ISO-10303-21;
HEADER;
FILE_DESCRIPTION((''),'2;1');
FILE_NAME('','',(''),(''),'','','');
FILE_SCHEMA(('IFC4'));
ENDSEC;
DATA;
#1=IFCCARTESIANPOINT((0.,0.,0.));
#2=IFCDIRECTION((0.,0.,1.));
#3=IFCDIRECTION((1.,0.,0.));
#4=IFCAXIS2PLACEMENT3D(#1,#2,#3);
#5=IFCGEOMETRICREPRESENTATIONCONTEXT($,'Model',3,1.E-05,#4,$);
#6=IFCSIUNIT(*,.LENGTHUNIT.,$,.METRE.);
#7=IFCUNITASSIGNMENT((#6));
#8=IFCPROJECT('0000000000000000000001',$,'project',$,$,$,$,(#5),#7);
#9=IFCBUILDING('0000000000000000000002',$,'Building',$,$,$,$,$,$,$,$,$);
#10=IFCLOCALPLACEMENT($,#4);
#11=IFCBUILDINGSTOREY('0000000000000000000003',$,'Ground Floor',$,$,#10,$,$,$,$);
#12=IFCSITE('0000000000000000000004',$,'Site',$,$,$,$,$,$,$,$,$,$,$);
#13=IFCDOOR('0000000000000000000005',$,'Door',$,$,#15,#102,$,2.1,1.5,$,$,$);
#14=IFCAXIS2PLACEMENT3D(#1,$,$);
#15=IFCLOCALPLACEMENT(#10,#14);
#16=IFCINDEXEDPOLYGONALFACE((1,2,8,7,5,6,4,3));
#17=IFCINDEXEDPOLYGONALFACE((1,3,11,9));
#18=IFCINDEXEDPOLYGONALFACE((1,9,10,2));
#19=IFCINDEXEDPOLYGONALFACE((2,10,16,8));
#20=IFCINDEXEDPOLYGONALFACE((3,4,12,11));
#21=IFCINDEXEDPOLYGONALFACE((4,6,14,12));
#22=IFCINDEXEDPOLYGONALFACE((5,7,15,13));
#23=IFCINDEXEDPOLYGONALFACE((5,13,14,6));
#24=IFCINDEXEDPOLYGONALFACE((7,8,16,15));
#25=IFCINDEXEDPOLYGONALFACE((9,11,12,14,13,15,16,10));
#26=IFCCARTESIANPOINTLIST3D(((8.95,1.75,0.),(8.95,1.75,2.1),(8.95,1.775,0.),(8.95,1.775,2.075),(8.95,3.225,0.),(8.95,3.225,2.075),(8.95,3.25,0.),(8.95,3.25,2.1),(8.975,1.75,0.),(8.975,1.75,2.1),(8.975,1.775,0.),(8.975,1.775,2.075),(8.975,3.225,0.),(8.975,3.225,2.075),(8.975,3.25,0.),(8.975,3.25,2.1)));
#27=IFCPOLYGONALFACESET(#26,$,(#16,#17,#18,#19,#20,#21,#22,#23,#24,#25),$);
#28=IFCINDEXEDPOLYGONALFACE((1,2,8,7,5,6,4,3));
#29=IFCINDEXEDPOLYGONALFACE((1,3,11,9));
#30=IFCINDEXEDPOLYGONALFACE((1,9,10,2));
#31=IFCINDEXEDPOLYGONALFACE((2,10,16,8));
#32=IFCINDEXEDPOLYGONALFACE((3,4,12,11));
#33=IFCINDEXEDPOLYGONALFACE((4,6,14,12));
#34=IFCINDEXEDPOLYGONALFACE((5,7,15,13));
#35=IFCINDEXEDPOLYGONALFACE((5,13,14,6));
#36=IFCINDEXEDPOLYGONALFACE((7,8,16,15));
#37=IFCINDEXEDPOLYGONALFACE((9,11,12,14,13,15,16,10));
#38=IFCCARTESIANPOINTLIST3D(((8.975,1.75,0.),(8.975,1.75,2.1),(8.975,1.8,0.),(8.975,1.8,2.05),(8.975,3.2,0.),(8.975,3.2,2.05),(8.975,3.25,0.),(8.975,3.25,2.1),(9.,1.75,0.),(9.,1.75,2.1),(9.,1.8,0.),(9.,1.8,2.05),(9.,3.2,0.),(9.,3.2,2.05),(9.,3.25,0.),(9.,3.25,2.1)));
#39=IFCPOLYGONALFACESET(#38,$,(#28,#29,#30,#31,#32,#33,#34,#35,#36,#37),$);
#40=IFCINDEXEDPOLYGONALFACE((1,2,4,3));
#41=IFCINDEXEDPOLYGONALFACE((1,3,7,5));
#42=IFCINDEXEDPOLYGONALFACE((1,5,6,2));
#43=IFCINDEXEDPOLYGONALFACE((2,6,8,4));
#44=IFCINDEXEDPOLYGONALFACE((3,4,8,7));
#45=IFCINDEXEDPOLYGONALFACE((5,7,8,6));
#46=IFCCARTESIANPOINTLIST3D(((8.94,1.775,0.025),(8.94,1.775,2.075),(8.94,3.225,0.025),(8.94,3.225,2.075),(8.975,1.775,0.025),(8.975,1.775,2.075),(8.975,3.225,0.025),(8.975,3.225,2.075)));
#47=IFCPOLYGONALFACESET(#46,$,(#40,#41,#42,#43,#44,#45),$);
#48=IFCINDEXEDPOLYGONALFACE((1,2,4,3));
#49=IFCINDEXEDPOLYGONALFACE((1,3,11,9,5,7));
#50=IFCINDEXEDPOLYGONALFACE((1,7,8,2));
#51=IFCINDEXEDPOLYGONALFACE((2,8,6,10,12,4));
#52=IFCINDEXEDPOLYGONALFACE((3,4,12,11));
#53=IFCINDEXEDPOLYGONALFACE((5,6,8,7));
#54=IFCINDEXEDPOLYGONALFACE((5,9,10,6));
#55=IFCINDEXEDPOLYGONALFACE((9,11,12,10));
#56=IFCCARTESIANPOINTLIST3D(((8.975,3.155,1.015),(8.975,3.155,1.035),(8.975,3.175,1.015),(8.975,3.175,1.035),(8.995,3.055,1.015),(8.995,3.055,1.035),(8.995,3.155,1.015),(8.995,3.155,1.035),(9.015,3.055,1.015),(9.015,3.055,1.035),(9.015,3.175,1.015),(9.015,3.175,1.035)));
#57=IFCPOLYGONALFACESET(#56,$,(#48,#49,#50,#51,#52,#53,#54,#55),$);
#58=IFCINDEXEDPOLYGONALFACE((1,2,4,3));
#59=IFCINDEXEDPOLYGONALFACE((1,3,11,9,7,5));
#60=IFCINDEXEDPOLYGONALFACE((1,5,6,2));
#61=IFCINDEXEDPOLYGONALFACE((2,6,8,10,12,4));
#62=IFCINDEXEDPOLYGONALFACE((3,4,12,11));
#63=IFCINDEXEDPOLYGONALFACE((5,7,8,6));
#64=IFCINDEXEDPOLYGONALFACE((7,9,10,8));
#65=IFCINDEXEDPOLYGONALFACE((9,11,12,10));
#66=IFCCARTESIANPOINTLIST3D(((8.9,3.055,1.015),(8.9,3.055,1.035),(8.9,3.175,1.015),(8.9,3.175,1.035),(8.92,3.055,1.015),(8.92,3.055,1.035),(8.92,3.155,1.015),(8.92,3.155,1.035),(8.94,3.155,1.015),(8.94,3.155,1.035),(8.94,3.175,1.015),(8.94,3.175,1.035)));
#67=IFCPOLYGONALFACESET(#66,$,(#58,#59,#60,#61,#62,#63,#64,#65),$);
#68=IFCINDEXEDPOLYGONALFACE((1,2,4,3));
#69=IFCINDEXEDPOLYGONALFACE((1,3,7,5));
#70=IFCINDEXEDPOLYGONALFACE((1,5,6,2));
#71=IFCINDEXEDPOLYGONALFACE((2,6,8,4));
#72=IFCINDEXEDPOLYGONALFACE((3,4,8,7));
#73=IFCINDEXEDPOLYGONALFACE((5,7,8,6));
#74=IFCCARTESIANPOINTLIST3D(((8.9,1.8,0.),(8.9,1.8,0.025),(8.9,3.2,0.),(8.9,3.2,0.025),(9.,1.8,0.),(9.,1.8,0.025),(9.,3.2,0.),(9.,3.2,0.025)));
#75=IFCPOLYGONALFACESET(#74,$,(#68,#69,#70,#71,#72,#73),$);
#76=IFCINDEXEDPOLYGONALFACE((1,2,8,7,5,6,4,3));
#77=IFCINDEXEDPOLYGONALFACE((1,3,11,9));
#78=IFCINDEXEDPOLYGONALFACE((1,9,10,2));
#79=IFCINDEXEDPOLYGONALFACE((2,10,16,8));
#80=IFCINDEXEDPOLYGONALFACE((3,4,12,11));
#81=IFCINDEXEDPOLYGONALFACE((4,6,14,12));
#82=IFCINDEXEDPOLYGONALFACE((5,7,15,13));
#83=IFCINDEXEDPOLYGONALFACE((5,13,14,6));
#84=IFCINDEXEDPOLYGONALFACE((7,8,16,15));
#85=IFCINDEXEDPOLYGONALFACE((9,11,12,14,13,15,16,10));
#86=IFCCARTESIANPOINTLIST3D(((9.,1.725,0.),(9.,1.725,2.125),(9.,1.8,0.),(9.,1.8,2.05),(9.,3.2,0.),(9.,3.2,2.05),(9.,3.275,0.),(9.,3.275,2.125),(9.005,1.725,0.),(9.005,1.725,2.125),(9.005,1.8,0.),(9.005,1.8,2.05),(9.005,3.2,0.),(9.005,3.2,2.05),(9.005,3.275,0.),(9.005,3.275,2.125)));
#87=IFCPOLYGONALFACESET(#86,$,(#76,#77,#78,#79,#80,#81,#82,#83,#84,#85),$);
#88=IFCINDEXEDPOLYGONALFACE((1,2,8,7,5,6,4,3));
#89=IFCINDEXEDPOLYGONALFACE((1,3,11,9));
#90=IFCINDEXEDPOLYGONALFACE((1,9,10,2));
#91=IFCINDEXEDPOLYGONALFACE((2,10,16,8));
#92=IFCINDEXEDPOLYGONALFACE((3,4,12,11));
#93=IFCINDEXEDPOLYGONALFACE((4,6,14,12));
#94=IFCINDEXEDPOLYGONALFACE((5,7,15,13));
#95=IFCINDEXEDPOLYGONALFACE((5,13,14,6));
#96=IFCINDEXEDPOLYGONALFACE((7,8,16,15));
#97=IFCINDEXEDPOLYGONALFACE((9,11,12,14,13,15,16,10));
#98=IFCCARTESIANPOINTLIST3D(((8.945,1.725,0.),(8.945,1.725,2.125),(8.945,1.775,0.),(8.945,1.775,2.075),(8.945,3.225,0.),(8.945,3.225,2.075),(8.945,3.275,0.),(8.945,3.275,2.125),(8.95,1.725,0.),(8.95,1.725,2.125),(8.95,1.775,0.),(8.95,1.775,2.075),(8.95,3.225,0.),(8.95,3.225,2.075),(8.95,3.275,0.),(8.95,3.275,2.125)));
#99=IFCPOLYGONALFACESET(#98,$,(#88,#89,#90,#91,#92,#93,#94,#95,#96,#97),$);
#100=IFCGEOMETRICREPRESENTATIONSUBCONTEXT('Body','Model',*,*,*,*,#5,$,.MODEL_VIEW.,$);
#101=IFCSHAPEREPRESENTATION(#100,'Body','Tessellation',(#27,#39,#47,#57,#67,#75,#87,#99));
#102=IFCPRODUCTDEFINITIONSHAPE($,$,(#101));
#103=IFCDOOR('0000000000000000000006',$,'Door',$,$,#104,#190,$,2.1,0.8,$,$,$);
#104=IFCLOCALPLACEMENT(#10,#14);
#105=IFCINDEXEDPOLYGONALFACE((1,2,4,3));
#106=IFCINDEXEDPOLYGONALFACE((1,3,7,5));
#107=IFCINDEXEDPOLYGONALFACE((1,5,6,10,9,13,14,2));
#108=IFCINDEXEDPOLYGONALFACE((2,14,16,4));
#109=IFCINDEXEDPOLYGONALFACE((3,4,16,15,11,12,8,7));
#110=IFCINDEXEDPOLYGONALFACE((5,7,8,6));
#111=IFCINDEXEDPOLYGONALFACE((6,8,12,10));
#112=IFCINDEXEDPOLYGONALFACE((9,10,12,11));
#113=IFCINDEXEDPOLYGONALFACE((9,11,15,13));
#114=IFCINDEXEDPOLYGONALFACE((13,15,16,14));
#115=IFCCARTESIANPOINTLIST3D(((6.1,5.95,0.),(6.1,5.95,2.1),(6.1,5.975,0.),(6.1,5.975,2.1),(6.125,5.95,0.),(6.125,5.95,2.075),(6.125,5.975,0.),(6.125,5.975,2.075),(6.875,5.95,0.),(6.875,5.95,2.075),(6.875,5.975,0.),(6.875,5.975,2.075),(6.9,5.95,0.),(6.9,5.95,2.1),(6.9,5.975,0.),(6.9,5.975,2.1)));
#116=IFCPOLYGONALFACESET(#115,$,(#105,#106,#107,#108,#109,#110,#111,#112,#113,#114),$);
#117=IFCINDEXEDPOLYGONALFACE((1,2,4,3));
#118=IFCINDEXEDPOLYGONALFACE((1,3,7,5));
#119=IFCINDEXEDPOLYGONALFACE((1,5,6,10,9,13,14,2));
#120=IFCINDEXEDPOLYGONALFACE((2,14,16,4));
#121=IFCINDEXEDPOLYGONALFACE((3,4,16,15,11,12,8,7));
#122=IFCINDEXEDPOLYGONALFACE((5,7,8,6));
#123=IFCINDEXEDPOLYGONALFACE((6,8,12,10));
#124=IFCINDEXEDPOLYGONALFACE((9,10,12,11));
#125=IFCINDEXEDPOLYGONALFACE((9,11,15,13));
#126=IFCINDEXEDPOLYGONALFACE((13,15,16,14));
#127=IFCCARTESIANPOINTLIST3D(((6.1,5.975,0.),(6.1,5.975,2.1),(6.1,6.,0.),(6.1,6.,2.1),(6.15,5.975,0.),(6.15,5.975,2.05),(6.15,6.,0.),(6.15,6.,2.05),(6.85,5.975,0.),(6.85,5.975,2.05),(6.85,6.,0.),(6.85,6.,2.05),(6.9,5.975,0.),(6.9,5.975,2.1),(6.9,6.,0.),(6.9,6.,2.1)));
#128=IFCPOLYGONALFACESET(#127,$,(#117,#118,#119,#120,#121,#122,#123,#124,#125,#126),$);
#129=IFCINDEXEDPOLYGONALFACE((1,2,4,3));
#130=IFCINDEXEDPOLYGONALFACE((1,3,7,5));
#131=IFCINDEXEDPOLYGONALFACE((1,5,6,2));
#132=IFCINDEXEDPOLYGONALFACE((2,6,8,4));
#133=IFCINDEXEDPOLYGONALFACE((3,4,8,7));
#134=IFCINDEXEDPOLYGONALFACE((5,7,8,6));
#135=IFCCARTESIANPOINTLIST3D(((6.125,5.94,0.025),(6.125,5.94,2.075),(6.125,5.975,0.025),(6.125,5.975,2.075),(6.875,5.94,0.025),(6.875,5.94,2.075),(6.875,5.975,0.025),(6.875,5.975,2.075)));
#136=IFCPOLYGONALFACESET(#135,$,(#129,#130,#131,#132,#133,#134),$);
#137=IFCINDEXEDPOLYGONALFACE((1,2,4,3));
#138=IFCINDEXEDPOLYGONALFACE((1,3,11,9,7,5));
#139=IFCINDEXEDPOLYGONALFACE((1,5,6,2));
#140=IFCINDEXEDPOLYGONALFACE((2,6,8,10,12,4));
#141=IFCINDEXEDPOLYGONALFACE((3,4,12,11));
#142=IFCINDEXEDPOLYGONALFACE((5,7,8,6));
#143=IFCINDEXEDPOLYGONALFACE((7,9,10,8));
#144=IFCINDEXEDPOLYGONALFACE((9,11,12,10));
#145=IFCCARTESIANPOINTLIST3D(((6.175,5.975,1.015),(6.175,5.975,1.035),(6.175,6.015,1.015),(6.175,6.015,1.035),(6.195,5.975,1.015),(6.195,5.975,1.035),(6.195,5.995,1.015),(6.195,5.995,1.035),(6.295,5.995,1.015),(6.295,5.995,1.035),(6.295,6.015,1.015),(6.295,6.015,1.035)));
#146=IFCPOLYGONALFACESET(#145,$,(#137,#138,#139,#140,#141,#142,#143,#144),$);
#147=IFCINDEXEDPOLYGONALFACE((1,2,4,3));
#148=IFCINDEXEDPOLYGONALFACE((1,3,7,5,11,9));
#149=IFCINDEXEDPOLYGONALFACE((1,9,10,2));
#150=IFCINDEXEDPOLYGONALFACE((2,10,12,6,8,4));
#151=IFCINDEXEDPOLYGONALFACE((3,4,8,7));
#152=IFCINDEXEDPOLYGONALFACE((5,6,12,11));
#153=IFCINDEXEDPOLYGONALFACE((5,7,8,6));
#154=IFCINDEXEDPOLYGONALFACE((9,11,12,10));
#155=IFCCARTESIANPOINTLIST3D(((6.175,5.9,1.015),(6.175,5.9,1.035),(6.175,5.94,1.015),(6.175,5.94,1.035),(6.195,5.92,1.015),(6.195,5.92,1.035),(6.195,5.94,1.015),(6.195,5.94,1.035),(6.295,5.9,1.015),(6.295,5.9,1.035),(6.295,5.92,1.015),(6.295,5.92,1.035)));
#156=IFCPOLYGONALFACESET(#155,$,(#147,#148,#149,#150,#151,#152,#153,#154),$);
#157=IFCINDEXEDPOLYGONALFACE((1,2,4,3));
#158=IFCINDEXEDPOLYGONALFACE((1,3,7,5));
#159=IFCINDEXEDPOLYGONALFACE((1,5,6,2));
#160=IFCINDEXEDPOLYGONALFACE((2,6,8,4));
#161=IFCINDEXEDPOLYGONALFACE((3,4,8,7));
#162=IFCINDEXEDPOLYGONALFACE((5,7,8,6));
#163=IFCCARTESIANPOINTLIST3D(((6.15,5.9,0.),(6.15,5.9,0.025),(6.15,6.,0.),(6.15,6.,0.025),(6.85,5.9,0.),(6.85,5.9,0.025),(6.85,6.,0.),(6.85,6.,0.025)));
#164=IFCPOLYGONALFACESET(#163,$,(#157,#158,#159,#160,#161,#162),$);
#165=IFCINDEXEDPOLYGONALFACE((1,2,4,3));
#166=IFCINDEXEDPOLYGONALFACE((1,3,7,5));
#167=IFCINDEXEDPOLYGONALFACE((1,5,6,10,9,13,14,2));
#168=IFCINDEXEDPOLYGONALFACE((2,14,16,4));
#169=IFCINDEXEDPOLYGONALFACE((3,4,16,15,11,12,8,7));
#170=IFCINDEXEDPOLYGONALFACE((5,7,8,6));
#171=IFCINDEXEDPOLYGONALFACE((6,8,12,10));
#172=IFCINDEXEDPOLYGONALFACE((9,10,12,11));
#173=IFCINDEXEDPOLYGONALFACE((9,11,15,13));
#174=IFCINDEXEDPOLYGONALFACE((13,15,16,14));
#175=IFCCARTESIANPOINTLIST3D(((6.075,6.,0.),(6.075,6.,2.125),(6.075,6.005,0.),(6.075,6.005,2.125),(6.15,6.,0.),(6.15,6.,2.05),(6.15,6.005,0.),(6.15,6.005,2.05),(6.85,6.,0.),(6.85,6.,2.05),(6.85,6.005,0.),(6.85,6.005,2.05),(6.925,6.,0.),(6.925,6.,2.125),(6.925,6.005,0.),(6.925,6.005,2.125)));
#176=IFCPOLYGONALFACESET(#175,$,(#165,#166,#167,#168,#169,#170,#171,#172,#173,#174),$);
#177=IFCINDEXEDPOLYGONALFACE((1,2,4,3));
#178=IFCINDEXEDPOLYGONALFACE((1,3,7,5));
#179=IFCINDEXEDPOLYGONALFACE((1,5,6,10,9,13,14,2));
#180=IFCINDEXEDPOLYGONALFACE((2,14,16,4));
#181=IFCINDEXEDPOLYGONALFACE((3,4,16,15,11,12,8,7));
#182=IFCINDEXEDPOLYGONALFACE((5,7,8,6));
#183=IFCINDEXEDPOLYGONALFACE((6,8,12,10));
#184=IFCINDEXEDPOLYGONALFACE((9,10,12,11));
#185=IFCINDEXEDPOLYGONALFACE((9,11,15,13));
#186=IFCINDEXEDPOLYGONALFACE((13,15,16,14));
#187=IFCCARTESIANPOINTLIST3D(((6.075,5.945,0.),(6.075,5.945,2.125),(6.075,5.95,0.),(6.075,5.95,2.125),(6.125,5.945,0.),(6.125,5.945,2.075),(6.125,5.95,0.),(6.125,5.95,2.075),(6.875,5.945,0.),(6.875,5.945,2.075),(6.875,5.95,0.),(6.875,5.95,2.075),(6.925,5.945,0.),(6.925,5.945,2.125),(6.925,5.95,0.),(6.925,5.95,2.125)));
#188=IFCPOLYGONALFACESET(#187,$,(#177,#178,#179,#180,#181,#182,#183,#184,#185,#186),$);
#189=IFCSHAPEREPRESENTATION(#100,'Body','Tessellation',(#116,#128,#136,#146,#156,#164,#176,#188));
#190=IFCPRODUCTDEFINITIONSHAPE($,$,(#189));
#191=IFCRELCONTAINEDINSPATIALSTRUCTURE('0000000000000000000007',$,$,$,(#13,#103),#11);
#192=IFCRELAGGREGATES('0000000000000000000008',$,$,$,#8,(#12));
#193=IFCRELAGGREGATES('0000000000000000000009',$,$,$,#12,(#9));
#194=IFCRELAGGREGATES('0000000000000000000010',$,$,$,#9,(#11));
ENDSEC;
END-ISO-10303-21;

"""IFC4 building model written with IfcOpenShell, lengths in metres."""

from ifc_helpers import new_model, si_unit, frame, origin_with_axes, place, context, subcontext, project, spatial, line, indexed_curve, outline, extrude, element, save


model = new_model("IFC4")

# Units and contexts
model_context = context("Model", 3, precision=1e-05, world=origin_with_axes())
body_context = subcontext(model_context, "Body", "Model", "MODEL_VIEW")
ifc_project = project(units=[si_unit("LENGTHUNIT", "METRE")], contexts=[model_context])

# Site, building, storey
site = spatial("IfcSite", under=ifc_project, Name="Site")
building = spatial("IfcBuilding", under=site, Name="Building")
storey_placement = place(None, origin_with_axes())
storey = spatial("IfcBuildingStorey", under=building, at=storey_placement, Name="Ground Floor")

# Doors
door_1_placement = place(storey_placement, frame((9.0, 1.75, 0.0), z_axis=(0.0, 0.0, 1.0), x_axis=(0.0, 1.0, 0.0)))
element("IfcDoor", 1, at=door_1_placement, inside=storey, Name="Door", OverallHeight=2.1, OverallWidth=1.5, context=body_context, shape_type="SweptSolid", body=[
    extrude(outline(indexed_curve([(0.0, 0.0), (0.0, 2.1), (1.5, 2.1), (1.5, 0.0), (1.475, 0.0), (1.475, 2.075), (0.025, 2.075), (0.025, 0.0)], segments=[line(1, 2, 3, 4, 5, 6, 7, 8, 1)])), frame((0.0, 0.025, 0.0), z_axis=(0.0, -1.0, 0.0), x_axis=(1.0, 0.0, 0.0)), (0.0, 0.0, -1.0), 0.025),
    extrude(outline(indexed_curve([(0.0, 0.0), (0.0, 2.1), (1.5, 2.1), (1.5, 0.0), (1.45, 0.0), (1.45, 2.05), (0.05, 2.05), (0.05, 0.0)], segments=[line(1, 2, 3, 4, 5, 6, 7, 8, 1)])), frame((0.0, 0.0, 0.0), z_axis=(0.0, -1.0, 0.0), x_axis=(1.0, 0.0, 0.0)), (0.0, 0.0, -1.0), 0.025),
    extrude(outline(indexed_curve([(0.0, 0.0), (1.45, 0.0), (1.45, 0.035), (0.0, 0.035)], segments=[line(1, 2, 3, 4, 1)])), frame((0.025, 0.025, 0.025), z_axis=(0.0, 0.0, 1.0), x_axis=(1.0, 0.0, 0.0)), (0.0, 0.0, 1.0), 2.05),
    extrude(outline(indexed_curve([(0.0, 0.0), (0.0, -0.04), (-0.12, -0.04), (-0.12, -0.02), (-0.02, -0.02), (-0.02, 0.0)], segments=[line(1, 2, 3, 4, 5, 6, 1)])), frame((1.425, 0.025, 1.015), z_axis=(0.0, 0.0, 1.0), x_axis=(1.0, 0.0, 0.0)), (0.0, 0.0, 1.0), 0.02),
    extrude(outline(indexed_curve([(0.0, 0.0), (0.0, 0.04), (-0.12, 0.04), (-0.12, 0.02), (-0.02, 0.02), (-0.02, 0.0)], segments=[line(1, 2, 3, 4, 5, 6, 1)])), frame((1.425, 0.06, 1.015), z_axis=(0.0, 0.0, 1.0), x_axis=(1.0, 0.0, 0.0)), (0.0, 0.0, 1.0), 0.02),
    extrude(outline(indexed_curve([(0.0, 0.0), (1.4, 0.0), (1.4, 0.1), (0.0, 0.1)], segments=[line(1, 2, 3, 4, 1)])), frame((0.05, 0.0, 0.0), z_axis=(0.0, 0.0, 1.0), x_axis=(1.0, 0.0, 0.0)), (0.0, 0.0, 1.0), 0.025),
    extrude(outline(indexed_curve([(0.0, 0.0), (0.0, 2.125), (1.55, 2.125), (1.55, 0.0), (1.475, 0.0), (1.475, 2.05), (0.075, 2.05), (0.075, 0.0)], segments=[line(1, 2, 3, 4, 5, 6, 7, 8, 1)])), frame((-0.025, -0.005, 0.0), z_axis=(0.0, -1.0, 0.0), x_axis=(1.0, 0.0, 0.0)), (0.0, 0.0, -1.0), 0.005),
    extrude(outline(indexed_curve([(0.0, 0.0), (0.0, 2.125), (1.55, 2.125), (1.55, 0.0), (1.5, 0.0), (1.5, 2.075), (0.05, 2.075), (0.05, 0.0)], segments=[line(1, 2, 3, 4, 5, 6, 7, 8, 1)])), frame((-0.025, 0.05, 0.0), z_axis=(0.0, -1.0, 0.0), x_axis=(1.0, 0.0, 0.0)), (0.0, 0.0, -1.0), 0.005),
])
door_2_placement = place(storey_placement, frame((6.9, 6.0, 0.0), z_axis=(0.0, 0.0, 1.0), x_axis=(-1.0, 0.0, 0.0)))
element("IfcDoor", 2, at=door_2_placement, inside=storey, Name="Door", OverallHeight=2.1, OverallWidth=0.8, context=body_context, shape_type="SweptSolid", body=[
    extrude(outline(indexed_curve([(0.0, 0.0), (0.0, 2.1), (0.8, 2.1), (0.8, 0.0), (0.775, 0.0), (0.775, 2.075), (0.025, 2.075), (0.025, 0.0)], segments=[line(1, 2, 3, 4, 5, 6, 7, 8, 1)])), frame((0.0, 0.025, 0.0), z_axis=(0.0, -1.0, 0.0), x_axis=(1.0, 0.0, 0.0)), (0.0, 0.0, -1.0), 0.025),
    extrude(outline(indexed_curve([(0.0, 0.0), (0.0, 2.1), (0.8, 2.1), (0.8, 0.0), (0.75, 0.0), (0.75, 2.05), (0.05, 2.05), (0.05, 0.0)], segments=[line(1, 2, 3, 4, 5, 6, 7, 8, 1)])), frame((0.0, 0.0, 0.0), z_axis=(0.0, -1.0, 0.0), x_axis=(1.0, 0.0, 0.0)), (0.0, 0.0, -1.0), 0.025),
    extrude(outline(indexed_curve([(0.0, 0.0), (0.75, 0.0), (0.75, 0.035), (0.0, 0.035)], segments=[line(1, 2, 3, 4, 1)])), frame((0.025, 0.025, 0.025), z_axis=(0.0, 0.0, 1.0), x_axis=(1.0, 0.0, 0.0)), (0.0, 0.0, 1.0), 2.05),
    extrude(outline(indexed_curve([(0.0, 0.0), (0.0, -0.04), (-0.12, -0.04), (-0.12, -0.02), (-0.02, -0.02), (-0.02, 0.0)], segments=[line(1, 2, 3, 4, 5, 6, 1)])), frame((0.725, 0.025, 1.015), z_axis=(0.0, 0.0, 1.0), x_axis=(1.0, 0.0, 0.0)), (0.0, 0.0, 1.0), 0.02),
    extrude(outline(indexed_curve([(0.0, 0.0), (0.0, 0.04), (-0.12, 0.04), (-0.12, 0.02), (-0.02, 0.02), (-0.02, 0.0)], segments=[line(1, 2, 3, 4, 5, 6, 1)])), frame((0.725, 0.06, 1.015), z_axis=(0.0, 0.0, 1.0), x_axis=(1.0, 0.0, 0.0)), (0.0, 0.0, 1.0), 0.02),
    extrude(outline(indexed_curve([(0.0, 0.0), (0.7, 0.0), (0.7, 0.1), (0.0, 0.1)], segments=[line(1, 2, 3, 4, 1)])), frame((0.05, 0.0, 0.0), z_axis=(0.0, 0.0, 1.0), x_axis=(1.0, 0.0, 0.0)), (0.0, 0.0, 1.0), 0.025),
    extrude(outline(indexed_curve([(0.0, 0.0), (0.0, 2.125), (0.85, 2.125), (0.85, 0.0), (0.775, 0.0), (0.775, 2.05), (0.075, 2.05), (0.075, 0.0)], segments=[line(1, 2, 3, 4, 5, 6, 7, 8, 1)])), frame((-0.025, -0.005, 0.0), z_axis=(0.0, -1.0, 0.0), x_axis=(1.0, 0.0, 0.0)), (0.0, 0.0, -1.0), 0.005),
    extrude(outline(indexed_curve([(0.0, 0.0), (0.0, 2.125), (0.85, 2.125), (0.85, 0.0), (0.8, 0.0), (0.8, 2.075), (0.05, 2.075), (0.05, 0.0)], segments=[line(1, 2, 3, 4, 5, 6, 7, 8, 1)])), frame((-0.025, 0.05, 0.0), z_axis=(0.0, -1.0, 0.0), x_axis=(1.0, 0.0, 0.0)), (0.0, 0.0, -1.0), 0.005),
])

save(model, "model.ifc")
